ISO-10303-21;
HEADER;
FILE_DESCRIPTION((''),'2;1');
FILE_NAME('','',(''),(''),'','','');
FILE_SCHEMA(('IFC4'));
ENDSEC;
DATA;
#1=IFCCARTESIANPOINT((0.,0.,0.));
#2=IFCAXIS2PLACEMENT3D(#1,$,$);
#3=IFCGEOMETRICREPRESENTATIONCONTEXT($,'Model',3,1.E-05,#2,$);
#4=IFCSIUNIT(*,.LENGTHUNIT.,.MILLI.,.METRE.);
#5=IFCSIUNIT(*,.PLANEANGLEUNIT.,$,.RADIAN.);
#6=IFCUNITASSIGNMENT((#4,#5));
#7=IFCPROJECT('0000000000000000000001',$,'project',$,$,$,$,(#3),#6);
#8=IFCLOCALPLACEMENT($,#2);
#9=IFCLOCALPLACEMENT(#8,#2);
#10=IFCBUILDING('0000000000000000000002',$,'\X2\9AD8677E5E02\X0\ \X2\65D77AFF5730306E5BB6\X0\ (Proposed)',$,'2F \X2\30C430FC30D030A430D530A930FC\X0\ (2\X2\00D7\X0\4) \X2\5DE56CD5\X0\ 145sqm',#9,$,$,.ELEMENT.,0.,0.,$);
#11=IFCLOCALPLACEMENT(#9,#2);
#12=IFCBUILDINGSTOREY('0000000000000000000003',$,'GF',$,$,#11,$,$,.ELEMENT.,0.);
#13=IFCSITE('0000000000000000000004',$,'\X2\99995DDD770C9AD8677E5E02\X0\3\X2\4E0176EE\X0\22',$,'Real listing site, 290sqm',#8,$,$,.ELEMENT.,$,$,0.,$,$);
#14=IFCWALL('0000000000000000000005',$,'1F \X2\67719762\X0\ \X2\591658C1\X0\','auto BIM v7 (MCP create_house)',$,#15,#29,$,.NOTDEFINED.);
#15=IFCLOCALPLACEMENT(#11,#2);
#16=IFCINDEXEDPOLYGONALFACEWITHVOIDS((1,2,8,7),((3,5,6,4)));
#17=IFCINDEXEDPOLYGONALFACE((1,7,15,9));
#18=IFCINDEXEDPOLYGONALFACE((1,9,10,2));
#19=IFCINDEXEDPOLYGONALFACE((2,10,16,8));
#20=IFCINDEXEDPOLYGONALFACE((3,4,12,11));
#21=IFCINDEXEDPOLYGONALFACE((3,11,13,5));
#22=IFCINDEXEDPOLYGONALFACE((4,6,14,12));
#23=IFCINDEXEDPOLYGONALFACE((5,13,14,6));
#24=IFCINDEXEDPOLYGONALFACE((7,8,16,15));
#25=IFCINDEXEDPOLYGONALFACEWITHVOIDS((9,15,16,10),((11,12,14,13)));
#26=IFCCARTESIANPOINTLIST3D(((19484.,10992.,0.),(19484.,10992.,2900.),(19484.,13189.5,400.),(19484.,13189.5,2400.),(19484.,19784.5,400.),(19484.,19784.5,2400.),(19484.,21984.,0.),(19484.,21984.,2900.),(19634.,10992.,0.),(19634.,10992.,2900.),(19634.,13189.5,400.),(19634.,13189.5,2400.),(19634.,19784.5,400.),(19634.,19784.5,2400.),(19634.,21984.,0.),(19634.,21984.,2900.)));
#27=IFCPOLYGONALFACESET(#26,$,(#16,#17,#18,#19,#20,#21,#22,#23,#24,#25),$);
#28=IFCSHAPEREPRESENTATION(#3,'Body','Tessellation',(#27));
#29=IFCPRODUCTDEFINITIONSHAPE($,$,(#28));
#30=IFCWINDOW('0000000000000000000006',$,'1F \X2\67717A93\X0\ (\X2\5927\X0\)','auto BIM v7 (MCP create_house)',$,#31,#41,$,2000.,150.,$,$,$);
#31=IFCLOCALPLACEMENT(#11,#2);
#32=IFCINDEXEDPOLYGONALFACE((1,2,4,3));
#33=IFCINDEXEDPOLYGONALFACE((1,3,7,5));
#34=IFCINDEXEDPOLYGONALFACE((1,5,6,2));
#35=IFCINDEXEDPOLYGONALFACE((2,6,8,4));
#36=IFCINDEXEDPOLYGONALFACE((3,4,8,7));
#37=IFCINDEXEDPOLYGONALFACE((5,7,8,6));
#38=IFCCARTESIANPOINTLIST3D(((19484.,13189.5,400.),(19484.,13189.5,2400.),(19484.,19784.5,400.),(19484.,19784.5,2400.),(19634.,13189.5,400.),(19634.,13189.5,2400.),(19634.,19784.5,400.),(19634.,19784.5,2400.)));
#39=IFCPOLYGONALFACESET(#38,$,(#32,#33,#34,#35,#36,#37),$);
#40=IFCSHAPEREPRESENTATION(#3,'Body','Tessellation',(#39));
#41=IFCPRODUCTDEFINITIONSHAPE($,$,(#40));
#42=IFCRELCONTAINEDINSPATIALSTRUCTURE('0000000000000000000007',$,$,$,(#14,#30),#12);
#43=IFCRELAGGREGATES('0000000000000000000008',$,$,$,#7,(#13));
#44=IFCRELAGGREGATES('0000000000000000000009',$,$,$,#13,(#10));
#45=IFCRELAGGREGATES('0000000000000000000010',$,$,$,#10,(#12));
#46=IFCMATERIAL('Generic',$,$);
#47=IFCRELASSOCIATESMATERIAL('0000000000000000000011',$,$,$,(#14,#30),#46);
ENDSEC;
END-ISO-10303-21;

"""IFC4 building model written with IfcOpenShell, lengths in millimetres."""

from ifc_helpers import new_model, si_unit, frame, frame_2d, origin, place, context, project, spatial, rectangle, extrude, material, element, fill, save


model = new_model("IFC4")

# Units and contexts
model_context = context("Model", 3, precision=1e-05, world=origin())
ifc_project = project(units=[si_unit("LENGTHUNIT", "METRE", prefix="MILLI"), si_unit("PLANEANGLEUNIT", "RADIAN")], contexts=[model_context])

# Site, building, storey
site_placement = place(None, origin())
site = spatial("IfcSite", under=ifc_project, at=site_placement, Name="香川県高松市3丁目22", ObjectType="Real listing site, 290sqm", CompositionType="ELEMENT", RefElevation=0.0)
building_placement = place(site_placement, origin())
building = spatial("IfcBuilding", under=site, at=building_placement, Name="高松市 旗竿地の家 (Proposed)", ObjectType="2F ツーバイフォー (2×4) 工法 145sqm", CompositionType="ELEMENT", ElevationOfRefHeight=0.0, ElevationOfTerrain=0.0)
storey_placement = place(building_placement, origin())
storey = spatial("IfcBuildingStorey", under=building, at=storey_placement, Name="GF", CompositionType="ELEMENT", Elevation=0.0)

# Shared definitions
ifc_material = material(Name="Generic")

# Wall, opening, window
wall_1_placement = place(storey_placement, frame((9742.0, 5496.0, 0.0)))
wall_1 = element("IfcWall", 1, at=wall_1_placement, inside=storey, material=ifc_material, Name="1F 東面 外壁", Description="auto BIM v7 (MCP create_house)", PredefinedType="NOTDEFINED", context=model_context, shape_type="SweptSolid", body=[
    extrude(rectangle(XDim=150.0, YDim=10992.0, at=frame_2d((75.0, 5496.0))), frame((9742.0, 5496.0, 0.0)), (0.0, 0.0, 1.0), 2900.0),
])
opening_1_placement = place(storey_placement, frame((9742.0, 6595.0, 200.0)))
opening_1 = element("IfcOpeningElement", 2, at=opening_1_placement, cuts=wall_1, PredefinedType="NOTDEFINED", context=model_context, shape_type="SweptSolid", body=[
    extrude(rectangle(XDim=150.0, YDim=6595.0, at=frame_2d((75.0, 3297.0))), frame((9742.0, 6595.0, 200.0)), (0.0, 0.0, 1.0), 2000.0),
])
window_1_placement = place(storey_placement, frame((9742.0, 6595.0, 200.0)))
window_1 = element("IfcWindow", 3, at=window_1_placement, inside=storey, material=ifc_material, Name="1F 東窓 (大)", Description="auto BIM v7 (MCP create_house)", OverallHeight=2000.0, OverallWidth=150.0, context=model_context, shape_type="SweptSolid", body=[
    extrude(rectangle(XDim=150.0, YDim=6595.0, at=frame_2d((75.0, 3297.0))), frame((9742.0, 6595.0, 200.0)), (0.0, 0.0, 1.0), 2000.0),
])
fill(opening_1, window_1)

save(model, "model.ifc")
